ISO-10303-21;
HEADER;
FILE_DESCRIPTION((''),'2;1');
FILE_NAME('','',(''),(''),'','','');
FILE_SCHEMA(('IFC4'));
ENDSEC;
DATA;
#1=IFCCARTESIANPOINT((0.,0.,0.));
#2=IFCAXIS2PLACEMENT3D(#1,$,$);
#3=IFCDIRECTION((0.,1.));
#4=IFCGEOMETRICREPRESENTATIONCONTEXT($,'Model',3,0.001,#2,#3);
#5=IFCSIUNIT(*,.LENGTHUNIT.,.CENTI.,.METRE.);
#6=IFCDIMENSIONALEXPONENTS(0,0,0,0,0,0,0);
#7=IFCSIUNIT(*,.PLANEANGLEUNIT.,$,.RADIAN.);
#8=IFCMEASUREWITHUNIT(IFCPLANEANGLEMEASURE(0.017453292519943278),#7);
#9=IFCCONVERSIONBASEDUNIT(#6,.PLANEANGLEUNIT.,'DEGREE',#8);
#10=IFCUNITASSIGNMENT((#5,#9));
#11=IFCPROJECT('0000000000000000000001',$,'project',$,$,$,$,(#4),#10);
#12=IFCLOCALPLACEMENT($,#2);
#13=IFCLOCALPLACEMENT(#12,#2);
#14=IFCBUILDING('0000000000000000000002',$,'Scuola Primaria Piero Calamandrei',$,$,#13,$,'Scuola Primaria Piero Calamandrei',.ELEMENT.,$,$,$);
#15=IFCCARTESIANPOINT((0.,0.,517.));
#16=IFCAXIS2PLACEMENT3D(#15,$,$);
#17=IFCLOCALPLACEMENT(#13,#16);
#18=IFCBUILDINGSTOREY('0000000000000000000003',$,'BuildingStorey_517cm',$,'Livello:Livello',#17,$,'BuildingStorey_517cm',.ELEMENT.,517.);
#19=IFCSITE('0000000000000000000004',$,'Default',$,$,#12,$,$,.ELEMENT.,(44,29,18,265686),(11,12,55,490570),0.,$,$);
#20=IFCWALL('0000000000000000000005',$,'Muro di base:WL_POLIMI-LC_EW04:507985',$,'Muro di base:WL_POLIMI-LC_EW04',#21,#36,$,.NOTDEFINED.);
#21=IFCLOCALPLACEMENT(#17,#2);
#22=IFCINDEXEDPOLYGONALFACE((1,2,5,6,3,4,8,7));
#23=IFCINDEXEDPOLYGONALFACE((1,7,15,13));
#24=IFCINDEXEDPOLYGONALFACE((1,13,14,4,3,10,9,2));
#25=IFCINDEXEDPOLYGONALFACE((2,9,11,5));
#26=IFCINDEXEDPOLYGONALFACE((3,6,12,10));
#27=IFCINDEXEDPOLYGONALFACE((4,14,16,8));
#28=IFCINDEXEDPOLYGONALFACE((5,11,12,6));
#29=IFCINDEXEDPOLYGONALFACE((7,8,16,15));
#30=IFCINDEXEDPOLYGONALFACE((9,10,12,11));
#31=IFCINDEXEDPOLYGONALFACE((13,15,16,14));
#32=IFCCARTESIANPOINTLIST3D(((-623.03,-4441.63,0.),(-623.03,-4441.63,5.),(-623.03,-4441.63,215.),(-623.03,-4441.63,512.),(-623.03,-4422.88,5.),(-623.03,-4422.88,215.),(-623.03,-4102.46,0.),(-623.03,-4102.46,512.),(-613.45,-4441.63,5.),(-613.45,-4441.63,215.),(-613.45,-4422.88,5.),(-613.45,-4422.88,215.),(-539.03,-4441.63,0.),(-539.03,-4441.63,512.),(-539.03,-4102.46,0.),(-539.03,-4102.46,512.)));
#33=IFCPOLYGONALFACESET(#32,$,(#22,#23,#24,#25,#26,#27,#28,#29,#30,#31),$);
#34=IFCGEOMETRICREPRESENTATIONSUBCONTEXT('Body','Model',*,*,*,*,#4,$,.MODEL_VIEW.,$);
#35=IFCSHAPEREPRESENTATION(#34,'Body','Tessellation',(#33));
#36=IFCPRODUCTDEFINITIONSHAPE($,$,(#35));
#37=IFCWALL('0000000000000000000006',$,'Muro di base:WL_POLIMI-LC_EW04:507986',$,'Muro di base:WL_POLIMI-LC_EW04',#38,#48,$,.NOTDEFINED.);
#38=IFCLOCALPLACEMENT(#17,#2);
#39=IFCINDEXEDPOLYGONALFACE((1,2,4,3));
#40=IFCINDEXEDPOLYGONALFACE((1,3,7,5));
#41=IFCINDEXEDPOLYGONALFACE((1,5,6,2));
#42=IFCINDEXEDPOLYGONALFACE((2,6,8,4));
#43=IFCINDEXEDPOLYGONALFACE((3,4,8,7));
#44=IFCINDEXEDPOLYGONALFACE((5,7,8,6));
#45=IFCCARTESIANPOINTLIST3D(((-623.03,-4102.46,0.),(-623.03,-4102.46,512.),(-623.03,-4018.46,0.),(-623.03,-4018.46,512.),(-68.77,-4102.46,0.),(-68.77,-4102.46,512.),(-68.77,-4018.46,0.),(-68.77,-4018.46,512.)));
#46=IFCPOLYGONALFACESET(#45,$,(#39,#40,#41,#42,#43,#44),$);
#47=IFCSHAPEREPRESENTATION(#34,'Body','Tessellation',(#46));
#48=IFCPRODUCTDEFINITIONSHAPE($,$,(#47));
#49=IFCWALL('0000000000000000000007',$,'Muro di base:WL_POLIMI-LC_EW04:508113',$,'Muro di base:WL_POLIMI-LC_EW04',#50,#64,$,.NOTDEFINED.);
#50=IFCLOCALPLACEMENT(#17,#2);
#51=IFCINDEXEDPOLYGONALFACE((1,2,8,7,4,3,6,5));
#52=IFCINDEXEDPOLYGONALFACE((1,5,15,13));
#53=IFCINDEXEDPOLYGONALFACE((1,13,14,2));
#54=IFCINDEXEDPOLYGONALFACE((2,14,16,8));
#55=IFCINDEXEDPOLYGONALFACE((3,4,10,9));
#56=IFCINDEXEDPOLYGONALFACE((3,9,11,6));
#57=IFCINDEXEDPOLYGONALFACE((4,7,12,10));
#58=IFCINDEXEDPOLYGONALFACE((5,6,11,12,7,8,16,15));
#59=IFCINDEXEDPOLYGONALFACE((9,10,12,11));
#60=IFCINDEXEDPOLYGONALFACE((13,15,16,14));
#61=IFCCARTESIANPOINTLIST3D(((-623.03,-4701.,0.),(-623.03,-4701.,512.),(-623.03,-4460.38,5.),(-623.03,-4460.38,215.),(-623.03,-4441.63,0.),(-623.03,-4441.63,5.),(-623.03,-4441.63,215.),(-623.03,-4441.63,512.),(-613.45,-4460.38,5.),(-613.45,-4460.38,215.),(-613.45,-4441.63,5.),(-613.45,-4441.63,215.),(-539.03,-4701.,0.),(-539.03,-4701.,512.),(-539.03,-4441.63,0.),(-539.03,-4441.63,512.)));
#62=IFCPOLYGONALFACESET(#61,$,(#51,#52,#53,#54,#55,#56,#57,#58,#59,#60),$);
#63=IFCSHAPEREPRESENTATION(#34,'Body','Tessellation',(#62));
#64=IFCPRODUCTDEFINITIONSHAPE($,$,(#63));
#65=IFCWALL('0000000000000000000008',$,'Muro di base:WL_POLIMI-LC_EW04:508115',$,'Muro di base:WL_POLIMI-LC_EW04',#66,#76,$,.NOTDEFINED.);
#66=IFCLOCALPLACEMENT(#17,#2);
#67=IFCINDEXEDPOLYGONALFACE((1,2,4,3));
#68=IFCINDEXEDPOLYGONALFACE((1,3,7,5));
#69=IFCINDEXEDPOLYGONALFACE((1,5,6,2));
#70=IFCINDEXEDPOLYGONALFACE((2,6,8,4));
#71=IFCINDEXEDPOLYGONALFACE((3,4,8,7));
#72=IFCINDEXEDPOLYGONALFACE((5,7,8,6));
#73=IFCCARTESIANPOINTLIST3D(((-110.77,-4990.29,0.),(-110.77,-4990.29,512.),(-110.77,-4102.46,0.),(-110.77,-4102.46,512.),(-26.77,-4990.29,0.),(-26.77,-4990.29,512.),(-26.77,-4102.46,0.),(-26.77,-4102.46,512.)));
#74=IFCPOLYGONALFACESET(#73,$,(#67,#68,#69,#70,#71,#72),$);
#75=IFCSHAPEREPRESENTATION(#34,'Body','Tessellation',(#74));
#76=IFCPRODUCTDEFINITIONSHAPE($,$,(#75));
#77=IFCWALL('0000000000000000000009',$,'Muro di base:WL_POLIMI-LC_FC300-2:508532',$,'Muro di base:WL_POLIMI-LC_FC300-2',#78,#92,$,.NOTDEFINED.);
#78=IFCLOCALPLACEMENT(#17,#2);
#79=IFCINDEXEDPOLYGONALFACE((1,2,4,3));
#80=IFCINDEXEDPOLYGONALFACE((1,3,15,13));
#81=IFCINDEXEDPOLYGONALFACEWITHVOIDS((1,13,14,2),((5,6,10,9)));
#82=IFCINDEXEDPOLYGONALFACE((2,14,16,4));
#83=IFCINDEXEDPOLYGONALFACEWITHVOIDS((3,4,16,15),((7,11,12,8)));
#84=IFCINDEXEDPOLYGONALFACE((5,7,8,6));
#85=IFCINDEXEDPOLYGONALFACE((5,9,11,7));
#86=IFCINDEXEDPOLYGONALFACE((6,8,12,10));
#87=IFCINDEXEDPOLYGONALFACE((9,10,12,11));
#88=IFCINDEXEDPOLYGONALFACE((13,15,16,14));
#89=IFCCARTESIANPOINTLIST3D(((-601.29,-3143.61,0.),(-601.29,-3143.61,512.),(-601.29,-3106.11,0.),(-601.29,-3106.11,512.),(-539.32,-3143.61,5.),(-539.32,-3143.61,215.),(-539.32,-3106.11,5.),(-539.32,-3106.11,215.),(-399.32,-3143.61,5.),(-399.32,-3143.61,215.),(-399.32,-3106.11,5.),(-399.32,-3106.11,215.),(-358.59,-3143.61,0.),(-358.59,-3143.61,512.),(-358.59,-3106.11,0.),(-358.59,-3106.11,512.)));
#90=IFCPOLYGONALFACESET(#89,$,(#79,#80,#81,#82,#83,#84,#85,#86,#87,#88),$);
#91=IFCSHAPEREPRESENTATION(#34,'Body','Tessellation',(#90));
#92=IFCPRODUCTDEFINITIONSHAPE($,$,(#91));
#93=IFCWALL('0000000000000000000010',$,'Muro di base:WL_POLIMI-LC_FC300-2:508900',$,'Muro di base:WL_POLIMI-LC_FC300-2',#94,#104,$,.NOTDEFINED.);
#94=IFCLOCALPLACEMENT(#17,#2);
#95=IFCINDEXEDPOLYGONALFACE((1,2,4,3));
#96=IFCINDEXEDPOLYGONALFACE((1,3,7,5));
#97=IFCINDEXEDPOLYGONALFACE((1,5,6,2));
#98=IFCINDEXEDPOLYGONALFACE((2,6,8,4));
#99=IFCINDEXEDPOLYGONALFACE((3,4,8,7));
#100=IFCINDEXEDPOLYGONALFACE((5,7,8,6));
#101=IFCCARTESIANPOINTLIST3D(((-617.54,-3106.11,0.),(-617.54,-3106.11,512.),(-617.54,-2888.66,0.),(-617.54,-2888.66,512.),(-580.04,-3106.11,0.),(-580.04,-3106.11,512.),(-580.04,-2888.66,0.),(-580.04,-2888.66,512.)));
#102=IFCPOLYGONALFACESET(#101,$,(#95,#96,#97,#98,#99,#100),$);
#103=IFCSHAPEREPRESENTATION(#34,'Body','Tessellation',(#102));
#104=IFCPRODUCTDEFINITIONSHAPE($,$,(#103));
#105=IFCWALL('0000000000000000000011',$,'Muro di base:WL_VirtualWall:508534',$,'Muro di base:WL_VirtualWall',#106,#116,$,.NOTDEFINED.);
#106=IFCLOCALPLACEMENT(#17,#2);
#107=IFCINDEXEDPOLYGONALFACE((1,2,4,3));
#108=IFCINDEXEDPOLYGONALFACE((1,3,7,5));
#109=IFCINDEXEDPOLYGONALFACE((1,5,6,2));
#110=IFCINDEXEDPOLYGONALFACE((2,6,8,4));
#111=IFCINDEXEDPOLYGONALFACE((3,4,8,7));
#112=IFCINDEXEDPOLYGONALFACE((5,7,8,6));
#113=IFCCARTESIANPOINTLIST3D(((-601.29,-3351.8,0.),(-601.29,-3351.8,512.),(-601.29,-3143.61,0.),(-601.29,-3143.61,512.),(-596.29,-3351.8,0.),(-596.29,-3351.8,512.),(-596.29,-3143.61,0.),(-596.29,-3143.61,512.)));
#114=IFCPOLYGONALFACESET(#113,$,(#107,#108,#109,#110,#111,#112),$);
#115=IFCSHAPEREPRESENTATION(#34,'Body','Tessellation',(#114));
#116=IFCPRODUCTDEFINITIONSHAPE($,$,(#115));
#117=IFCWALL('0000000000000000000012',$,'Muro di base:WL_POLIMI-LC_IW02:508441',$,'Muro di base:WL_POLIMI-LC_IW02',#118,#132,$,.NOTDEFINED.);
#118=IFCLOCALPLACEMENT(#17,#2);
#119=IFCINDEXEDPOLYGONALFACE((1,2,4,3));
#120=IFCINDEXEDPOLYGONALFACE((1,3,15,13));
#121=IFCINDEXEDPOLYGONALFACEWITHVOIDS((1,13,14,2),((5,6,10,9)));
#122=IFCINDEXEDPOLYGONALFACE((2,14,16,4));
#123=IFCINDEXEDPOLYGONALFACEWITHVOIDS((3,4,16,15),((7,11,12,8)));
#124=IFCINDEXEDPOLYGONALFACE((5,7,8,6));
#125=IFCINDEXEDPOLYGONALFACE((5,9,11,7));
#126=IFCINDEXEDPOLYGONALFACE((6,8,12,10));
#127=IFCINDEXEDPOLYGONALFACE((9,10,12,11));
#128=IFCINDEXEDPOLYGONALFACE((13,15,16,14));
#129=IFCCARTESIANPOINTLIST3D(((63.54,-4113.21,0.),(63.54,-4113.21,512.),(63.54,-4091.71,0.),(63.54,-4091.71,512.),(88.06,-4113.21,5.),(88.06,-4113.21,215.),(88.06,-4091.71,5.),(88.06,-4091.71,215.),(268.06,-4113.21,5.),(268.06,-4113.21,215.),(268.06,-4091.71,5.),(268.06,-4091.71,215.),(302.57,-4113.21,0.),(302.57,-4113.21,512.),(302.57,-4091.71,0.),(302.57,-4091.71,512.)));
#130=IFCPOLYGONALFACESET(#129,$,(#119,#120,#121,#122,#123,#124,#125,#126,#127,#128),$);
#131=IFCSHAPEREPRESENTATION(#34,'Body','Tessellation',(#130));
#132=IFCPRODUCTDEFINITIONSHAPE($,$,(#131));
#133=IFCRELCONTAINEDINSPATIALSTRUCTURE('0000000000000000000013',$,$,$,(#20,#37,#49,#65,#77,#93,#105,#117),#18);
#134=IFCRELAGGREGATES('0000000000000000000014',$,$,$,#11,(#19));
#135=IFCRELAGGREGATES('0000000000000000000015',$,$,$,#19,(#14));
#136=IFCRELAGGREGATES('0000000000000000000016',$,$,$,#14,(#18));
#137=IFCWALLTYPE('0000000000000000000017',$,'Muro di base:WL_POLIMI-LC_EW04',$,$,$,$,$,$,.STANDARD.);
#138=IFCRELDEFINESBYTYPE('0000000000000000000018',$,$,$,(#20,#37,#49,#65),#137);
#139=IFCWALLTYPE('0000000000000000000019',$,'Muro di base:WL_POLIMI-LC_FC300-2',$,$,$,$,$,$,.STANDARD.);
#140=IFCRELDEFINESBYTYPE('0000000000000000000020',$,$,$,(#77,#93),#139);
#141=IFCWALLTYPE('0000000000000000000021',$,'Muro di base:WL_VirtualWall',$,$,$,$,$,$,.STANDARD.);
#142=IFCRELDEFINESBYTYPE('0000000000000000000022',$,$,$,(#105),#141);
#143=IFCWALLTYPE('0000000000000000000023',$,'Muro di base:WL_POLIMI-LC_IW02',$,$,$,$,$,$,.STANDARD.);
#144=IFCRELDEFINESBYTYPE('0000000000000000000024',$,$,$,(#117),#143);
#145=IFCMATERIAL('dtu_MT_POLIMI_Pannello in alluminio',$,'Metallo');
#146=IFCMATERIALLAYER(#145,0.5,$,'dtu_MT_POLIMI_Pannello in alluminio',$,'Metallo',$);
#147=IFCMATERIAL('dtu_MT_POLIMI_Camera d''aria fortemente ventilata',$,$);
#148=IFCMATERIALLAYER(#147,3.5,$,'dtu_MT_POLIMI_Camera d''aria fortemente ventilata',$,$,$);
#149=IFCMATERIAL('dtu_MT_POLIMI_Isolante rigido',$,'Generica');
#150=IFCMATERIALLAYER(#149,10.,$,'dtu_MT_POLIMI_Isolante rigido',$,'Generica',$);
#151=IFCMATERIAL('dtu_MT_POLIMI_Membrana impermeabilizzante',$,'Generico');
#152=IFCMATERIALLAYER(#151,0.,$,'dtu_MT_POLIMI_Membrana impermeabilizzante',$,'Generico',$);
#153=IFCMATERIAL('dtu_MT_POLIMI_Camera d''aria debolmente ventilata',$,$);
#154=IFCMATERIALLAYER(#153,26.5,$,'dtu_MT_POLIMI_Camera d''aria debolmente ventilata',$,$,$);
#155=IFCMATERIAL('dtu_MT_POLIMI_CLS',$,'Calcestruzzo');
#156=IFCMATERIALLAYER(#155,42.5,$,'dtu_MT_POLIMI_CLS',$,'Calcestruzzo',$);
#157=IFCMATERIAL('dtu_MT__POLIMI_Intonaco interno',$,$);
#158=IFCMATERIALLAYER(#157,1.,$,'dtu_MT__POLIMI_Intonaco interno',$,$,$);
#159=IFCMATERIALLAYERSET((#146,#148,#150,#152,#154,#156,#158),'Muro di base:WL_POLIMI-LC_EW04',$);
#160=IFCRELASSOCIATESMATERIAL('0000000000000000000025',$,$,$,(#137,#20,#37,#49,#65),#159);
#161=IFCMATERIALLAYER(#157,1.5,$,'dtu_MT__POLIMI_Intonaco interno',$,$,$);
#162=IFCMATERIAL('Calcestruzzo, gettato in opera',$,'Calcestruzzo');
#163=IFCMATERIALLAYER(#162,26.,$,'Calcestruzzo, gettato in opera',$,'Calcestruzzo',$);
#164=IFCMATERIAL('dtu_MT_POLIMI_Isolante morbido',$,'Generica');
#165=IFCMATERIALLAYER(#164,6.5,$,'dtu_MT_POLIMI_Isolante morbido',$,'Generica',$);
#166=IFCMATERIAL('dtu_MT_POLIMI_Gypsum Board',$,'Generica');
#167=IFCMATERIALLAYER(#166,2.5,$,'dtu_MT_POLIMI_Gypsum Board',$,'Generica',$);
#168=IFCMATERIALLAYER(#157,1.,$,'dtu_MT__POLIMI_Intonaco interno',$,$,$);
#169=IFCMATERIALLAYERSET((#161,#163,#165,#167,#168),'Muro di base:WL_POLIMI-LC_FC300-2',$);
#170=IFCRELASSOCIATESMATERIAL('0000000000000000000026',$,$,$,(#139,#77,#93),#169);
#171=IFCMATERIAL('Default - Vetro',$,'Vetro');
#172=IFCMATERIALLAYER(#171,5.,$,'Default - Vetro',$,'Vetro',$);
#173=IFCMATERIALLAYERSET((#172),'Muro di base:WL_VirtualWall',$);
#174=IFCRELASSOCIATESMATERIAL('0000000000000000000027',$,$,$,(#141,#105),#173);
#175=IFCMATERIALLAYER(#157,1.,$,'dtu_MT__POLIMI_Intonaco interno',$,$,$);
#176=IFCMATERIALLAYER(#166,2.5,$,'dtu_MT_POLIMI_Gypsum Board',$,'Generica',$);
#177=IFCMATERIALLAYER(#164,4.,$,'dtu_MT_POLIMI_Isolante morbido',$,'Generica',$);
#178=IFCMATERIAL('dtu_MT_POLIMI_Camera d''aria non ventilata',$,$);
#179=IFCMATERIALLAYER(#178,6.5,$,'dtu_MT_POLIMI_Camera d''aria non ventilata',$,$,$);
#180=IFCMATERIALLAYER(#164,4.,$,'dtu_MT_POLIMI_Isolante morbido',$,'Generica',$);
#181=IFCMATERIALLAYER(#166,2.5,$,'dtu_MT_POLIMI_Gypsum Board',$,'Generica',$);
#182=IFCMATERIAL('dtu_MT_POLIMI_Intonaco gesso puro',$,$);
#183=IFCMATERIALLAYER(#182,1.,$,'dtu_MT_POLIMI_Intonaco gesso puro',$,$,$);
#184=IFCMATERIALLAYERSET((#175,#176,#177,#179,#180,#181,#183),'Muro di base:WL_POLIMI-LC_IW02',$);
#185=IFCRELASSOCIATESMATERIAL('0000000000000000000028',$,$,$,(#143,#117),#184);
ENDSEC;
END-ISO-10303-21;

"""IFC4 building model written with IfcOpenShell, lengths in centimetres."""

from ifc_helpers import new_model, entity, si_unit, converted_unit, direction, frame, frame_2d, origin, place, context, subcontext, project, spatial, rectangle, extrude, material, layer, layer_set, layer_usage, type_object, element, save


model = new_model("IFC4")

# Units and contexts
model_context = context("Model", 3, precision=0.001, world=origin(), true_north=direction((0.0, 1.0)))
body_context = subcontext(model_context, "Body", "Model", "MODEL_VIEW")
ifc_project = project(units=[si_unit("LENGTHUNIT", "METRE", prefix="CENTI"), converted_unit("PLANEANGLEUNIT", "DEGREE", entity("IfcPlaneAngleMeasure", 0.017453292519943278), si_unit("PLANEANGLEUNIT", "RADIAN"), dimensions=[0, 0, 0, 0, 0, 0, 0])], contexts=[model_context])

# Site, building, storey
site_placement = place(None, origin())
site = spatial("IfcSite", under=ifc_project, at=site_placement, Name="Default", CompositionType="ELEMENT", RefLatitude=(44, 29, 18, 265686), RefLongitude=(11, 12, 55, 490570), RefElevation=0.0)
building_placement = place(site_placement, origin())
building = spatial("IfcBuilding", under=site, at=building_placement, Name="Scuola Primaria Piero Calamandrei", LongName="Scuola Primaria Piero Calamandrei", CompositionType="ELEMENT")
storey_placement = place(building_placement, frame((0.0, 0.0, 517.0)))
storey = spatial("IfcBuildingStorey", under=building, at=storey_placement, Name="BuildingStorey_517cm", ObjectType="Livello:Livello", LongName="BuildingStorey_517cm", CompositionType="ELEMENT", Elevation=517.0)

# Wall, opening
ifc_material_1 = material(Name="dtu_MT_POLIMI_Pannello in alluminio", Category="Metallo")
ifc_layer_1 = layer(ifc_material_1, 0.5, Name="dtu_MT_POLIMI_Pannello in alluminio", Category="Metallo")
ifc_material_2 = material(Name="dtu_MT_POLIMI_Camera d'aria fortemente ventilata")
ifc_layer_2 = layer(ifc_material_2, 3.5, Name="dtu_MT_POLIMI_Camera d'aria fortemente ventilata")
ifc_material_3 = material(Name="dtu_MT_POLIMI_Isolante rigido", Category="Generica")
ifc_layer_3 = layer(ifc_material_3, 10.0, Name="dtu_MT_POLIMI_Isolante rigido", Category="Generica")
ifc_material_4 = material(Name="dtu_MT_POLIMI_Membrana impermeabilizzante", Category="Generico")
ifc_layer_4 = layer(ifc_material_4, 0.0, Name="dtu_MT_POLIMI_Membrana impermeabilizzante", Category="Generico")
ifc_material_5 = material(Name="dtu_MT_POLIMI_Camera d'aria debolmente ventilata")
ifc_layer_5 = layer(ifc_material_5, 26.5, Name="dtu_MT_POLIMI_Camera d'aria debolmente ventilata")
ifc_material_6 = material(Name="dtu_MT_POLIMI_CLS", Category="Calcestruzzo")
ifc_layer_6 = layer(ifc_material_6, 42.5, Name="dtu_MT_POLIMI_CLS", Category="Calcestruzzo")
ifc_material_7 = material(Name="dtu_MT__POLIMI_Intonaco interno")
ifc_layer_7 = layer(ifc_material_7, 1.0, Name="dtu_MT__POLIMI_Intonaco interno")
ifc_layer_set_1 = layer_set([ifc_layer_1, ifc_layer_2, ifc_layer_3, ifc_layer_4, ifc_layer_5, ifc_layer_6, ifc_layer_7], Name="Muro di base:WL_POLIMI-LC_EW04")
ifc_layer_usage_1 = layer_usage(ifc_layer_set_1, "AXIS2", "NEGATIVE", 42.0)
wall_type_1 = type_object("IfcWallType", Name="Muro di base:WL_POLIMI-LC_EW04", PredefinedType="STANDARD", material=ifc_layer_set_1)
wall_1_placement = place(storey_placement, frame((-581.03, -4102.46, 0.0), z_axis=(0.0, 0.0, 1.0), x_axis=(0.0, -1.0, 0.0)))
wall_1 = element("IfcWall", 1, at=wall_1_placement, inside=storey, type_object=wall_type_1, material=ifc_layer_usage_1, Name="Muro di base:WL_POLIMI-LC_EW04:507985", ObjectType="Muro di base:WL_POLIMI-LC_EW04", PredefinedType="NOTDEFINED", context=body_context, shape_type="SweptSolid", body=[
    extrude(rectangle(XDim=339.17, YDim=84.0, at=frame_2d((169.58, 0.0), x_axis=(-1.0, 0.0))), origin(), (0.0, 0.0, 1.0), 512.0),
])
opening_1_placement = place(wall_1_placement, frame((-4102.46, 581.03, 5.0)))
element("IfcOpeningElement", 2, at=opening_1_placement, cuts=wall_1, PredefinedType="OPENING", context=body_context, shape_type="SweptSolid", body=[
    extrude(rectangle(XDim=210.0, YDim=37.5, at=frame_2d((0.0, 0.0), x_axis=(0.0, 1.0))), frame((4441.63, -753.45, 105.0), z_axis=(0.0, 1.0, 0.0), x_axis=(1.0, 0.0, 0.0)), (0.0, 0.0, 1.0), 140.0),
])

# Wall
ifc_layer_usage_2 = layer_usage(ifc_layer_set_1, "AXIS2", "NEGATIVE", 42.0)
wall_2_placement = place(storey_placement, frame((-68.77, -4060.46, 0.0), z_axis=(0.0, 0.0, 1.0), x_axis=(-1.0, 0.0, 0.0)))
element("IfcWall", 3, at=wall_2_placement, inside=storey, type_object=wall_type_1, material=ifc_layer_usage_2, Name="Muro di base:WL_POLIMI-LC_EW04:507986", ObjectType="Muro di base:WL_POLIMI-LC_EW04", PredefinedType="NOTDEFINED", context=body_context, shape_type="SweptSolid", body=[
    extrude(rectangle(XDim=554.26, YDim=84.0, at=frame_2d((277.13, 0.0), x_axis=(-1.0, 0.0))), origin(), (0.0, 0.0, 1.0), 512.0),
])

# Wall, opening
ifc_layer_usage_3 = layer_usage(ifc_layer_set_1, "AXIS2", "NEGATIVE", 42.0)
wall_3_placement = place(storey_placement, frame((-581.03, -4441.63, 0.0), z_axis=(0.0, 0.0, 1.0), x_axis=(0.0, -1.0, 0.0)))
wall_3 = element("IfcWall", 4, at=wall_3_placement, inside=storey, type_object=wall_type_1, material=ifc_layer_usage_3, Name="Muro di base:WL_POLIMI-LC_EW04:508113", ObjectType="Muro di base:WL_POLIMI-LC_EW04", PredefinedType="NOTDEFINED", context=body_context, shape_type="SweptSolid", body=[
    extrude(rectangle(XDim=259.36, YDim=84.0, at=frame_2d((129.68, 0.0), x_axis=(-1.0, 0.0))), origin(), (0.0, 0.0, 1.0), 512.0),
])
opening_2_placement = place(wall_3_placement, frame((-4441.63, 581.03, 5.0)))
element("IfcOpeningElement", 5, at=opening_2_placement, cuts=wall_3, PredefinedType="OPENING", context=body_context, shape_type="SweptSolid", body=[
    extrude(rectangle(XDim=210.0, YDim=37.5, at=frame_2d((0.0, 0.0), x_axis=(0.0, 1.0))), frame((4441.63, -753.45, 105.0), z_axis=(0.0, 1.0, 0.0), x_axis=(1.0, 0.0, 0.0)), (0.0, 0.0, 1.0), 140.0),
])

# Wall
ifc_layer_usage_4 = layer_usage(ifc_layer_set_1, "AXIS2", "NEGATIVE", 42.0)
wall_4_placement = place(storey_placement, frame((-68.77, -4990.29, 0.0), z_axis=(0.0, 0.0, 1.0), x_axis=(0.0, 1.0, 0.0)))
element("IfcWall", 6, at=wall_4_placement, inside=storey, type_object=wall_type_1, material=ifc_layer_usage_4, Name="Muro di base:WL_POLIMI-LC_EW04:508115", ObjectType="Muro di base:WL_POLIMI-LC_EW04", PredefinedType="NOTDEFINED", context=body_context, shape_type="SweptSolid", body=[
    extrude(rectangle(XDim=887.82, YDim=84.0, at=frame_2d((443.91, 0.0), x_axis=(-1.0, 0.0))), origin(), (0.0, 0.0, 1.0), 512.0),
])
ifc_layer_8 = layer(ifc_material_7, 1.5, Name="dtu_MT__POLIMI_Intonaco interno")
ifc_material_8 = material(Name="Calcestruzzo, gettato in opera", Category="Calcestruzzo")
ifc_layer_9 = layer(ifc_material_8, 26.0, Name="Calcestruzzo, gettato in opera", Category="Calcestruzzo")
ifc_material_9 = material(Name="dtu_MT_POLIMI_Isolante morbido", Category="Generica")
ifc_layer_10 = layer(ifc_material_9, 6.5, Name="dtu_MT_POLIMI_Isolante morbido", Category="Generica")
ifc_material_10 = material(Name="dtu_MT_POLIMI_Gypsum Board", Category="Generica")
ifc_layer_11 = layer(ifc_material_10, 2.5, Name="dtu_MT_POLIMI_Gypsum Board", Category="Generica")
ifc_layer_12 = layer(ifc_material_7, 1.0, Name="dtu_MT__POLIMI_Intonaco interno")
ifc_layer_set_2 = layer_set([ifc_layer_8, ifc_layer_9, ifc_layer_10, ifc_layer_11, ifc_layer_12], Name="Muro di base:WL_POLIMI-LC_FC300-2")
wall_type_2 = type_object("IfcWallType", Name="Muro di base:WL_POLIMI-LC_FC300-2", PredefinedType="STANDARD", material=ifc_layer_set_2)

# Wall, opening
ifc_layer_usage_5 = layer_usage(ifc_layer_set_2, "AXIS2", "NEGATIVE", 18.75)
wall_5_placement = place(storey_placement, frame((-601.29, -3124.86, 0.0)))
wall_5 = element("IfcWall", 7, at=wall_5_placement, inside=storey, type_object=wall_type_2, material=ifc_layer_usage_5, Name="Muro di base:WL_POLIMI-LC_FC300-2:508532", ObjectType="Muro di base:WL_POLIMI-LC_FC300-2", PredefinedType="NOTDEFINED", context=body_context, shape_type="SweptSolid", body=[
    extrude(rectangle(XDim=242.7, YDim=37.5, at=frame_2d((121.35, 0.0), x_axis=(-1.0, 0.0))), origin(), (0.0, 0.0, 1.0), 512.0),
])
opening_3_placement = place(wall_5_placement, frame((61.98, -18.75, 5.0)))
element("IfcOpeningElement", 8, at=opening_3_placement, cuts=wall_5, PredefinedType="OPENING", context=body_context, shape_type="SweptSolid", body=[
    extrude(rectangle(XDim=210.0, YDim=140.0, at=frame_2d((105.0, 70.0), x_axis=(1.0, 0.0))), frame((0.0, 0.0, 0.0), z_axis=(0.0, 1.0, 0.0), x_axis=(0.0, 0.0, 1.0)), (0.0, 0.0, 1.0), 37.5),
])

# Walls
ifc_layer_usage_6 = layer_usage(ifc_layer_set_2, "AXIS2", "NEGATIVE", 18.75)
wall_6_placement = place(storey_placement, frame((-598.79, -2888.66, 0.0), z_axis=(0.0, 0.0, 1.0), x_axis=(0.0, -1.0, 0.0)))
element("IfcWall", 9, at=wall_6_placement, inside=storey, type_object=wall_type_2, material=ifc_layer_usage_6, Name="Muro di base:WL_POLIMI-LC_FC300-2:508900", ObjectType="Muro di base:WL_POLIMI-LC_FC300-2", PredefinedType="NOTDEFINED", context=body_context, shape_type="SweptSolid", body=[
    extrude(rectangle(XDim=217.44, YDim=37.5, at=frame_2d((108.72, 0.0), x_axis=(-1.0, 0.0))), origin(), (0.0, 0.0, 1.0), 512.0),
])
ifc_material_11 = material(Name="Default - Vetro", Category="Vetro")
ifc_layer_13 = layer(ifc_material_11, 5.0, Name="Default - Vetro", Category="Vetro")
ifc_layer_set_3 = layer_set([ifc_layer_13], Name="Muro di base:WL_VirtualWall")
ifc_layer_usage_7 = layer_usage(ifc_layer_set_3, "AXIS2", "NEGATIVE", 2.5)
wall_type_3 = type_object("IfcWallType", Name="Muro di base:WL_VirtualWall", PredefinedType="STANDARD", material=ifc_layer_set_3)
wall_7_placement = place(storey_placement, frame((-598.79, -3351.8, 0.0), z_axis=(0.0, 0.0, 1.0), x_axis=(0.0, 1.0, 0.0)))
element("IfcWall", 10, at=wall_7_placement, inside=storey, type_object=wall_type_3, material=ifc_layer_usage_7, Name="Muro di base:WL_VirtualWall:508534", ObjectType="Muro di base:WL_VirtualWall", PredefinedType="NOTDEFINED", context=body_context, shape_type="SweptSolid", body=[
    extrude(rectangle(XDim=208.19, YDim=5.0, at=frame_2d((104.09, 0.0), x_axis=(-1.0, 0.0))), origin(), (0.0, 0.0, 1.0), 512.0),
])

# Wall, opening
ifc_layer_14 = layer(ifc_material_7, 1.0, Name="dtu_MT__POLIMI_Intonaco interno")
ifc_layer_15 = layer(ifc_material_10, 2.5, Name="dtu_MT_POLIMI_Gypsum Board", Category="Generica")
ifc_layer_16 = layer(ifc_material_9, 4.0, Name="dtu_MT_POLIMI_Isolante morbido", Category="Generica")
ifc_material_12 = material(Name="dtu_MT_POLIMI_Camera d'aria non ventilata")
ifc_layer_17 = layer(ifc_material_12, 6.5, Name="dtu_MT_POLIMI_Camera d'aria non ventilata")
ifc_layer_18 = layer(ifc_material_9, 4.0, Name="dtu_MT_POLIMI_Isolante morbido", Category="Generica")
ifc_layer_19 = layer(ifc_material_10, 2.5, Name="dtu_MT_POLIMI_Gypsum Board", Category="Generica")
ifc_material_13 = material(Name="dtu_MT_POLIMI_Intonaco gesso puro")
ifc_layer_20 = layer(ifc_material_13, 1.0, Name="dtu_MT_POLIMI_Intonaco gesso puro")
ifc_layer_set_4 = layer_set([ifc_layer_14, ifc_layer_15, ifc_layer_16, ifc_layer_17, ifc_layer_18, ifc_layer_19, ifc_layer_20], Name="Muro di base:WL_POLIMI-LC_IW02")
ifc_layer_usage_8 = layer_usage(ifc_layer_set_4, "AXIS2", "NEGATIVE", 10.75)
wall_type_4 = type_object("IfcWallType", Name="Muro di base:WL_POLIMI-LC_IW02", PredefinedType="STANDARD", material=ifc_layer_set_4)
wall_8_placement = place(storey_placement, frame((302.57, -4102.46, 0.0), z_axis=(0.0, 0.0, 1.0), x_axis=(-1.0, 0.0, 0.0)))
wall_8 = element("IfcWall", 11, at=wall_8_placement, inside=storey, type_object=wall_type_4, material=ifc_layer_usage_8, Name="Muro di base:WL_POLIMI-LC_IW02:508441", ObjectType="Muro di base:WL_POLIMI-LC_IW02", PredefinedType="NOTDEFINED", context=body_context, shape_type="SweptSolid", body=[
    extrude(rectangle(XDim=239.03, YDim=21.5, at=frame_2d((119.52, 0.0), x_axis=(-1.0, 0.0))), origin(), (0.0, 0.0, 1.0), 512.0),
])
opening_4_placement = place(wall_8_placement, frame((214.52, 10.75, 5.0)))
element("IfcOpeningElement", 12, at=opening_4_placement, cuts=wall_8, PredefinedType="OPENING", context=body_context, shape_type="SweptSolid", body=[
    extrude(rectangle(XDim=210.0, YDim=180.0, at=frame_2d((105.0, 90.0), x_axis=(-1.0, 0.0))), frame((0.0, 0.0, 0.0), z_axis=(0.0, -1.0, 0.0), x_axis=(0.0, 0.0, 1.0)), (0.0, 0.0, 1.0), 21.5),
])

save(model, "model.ifc")
